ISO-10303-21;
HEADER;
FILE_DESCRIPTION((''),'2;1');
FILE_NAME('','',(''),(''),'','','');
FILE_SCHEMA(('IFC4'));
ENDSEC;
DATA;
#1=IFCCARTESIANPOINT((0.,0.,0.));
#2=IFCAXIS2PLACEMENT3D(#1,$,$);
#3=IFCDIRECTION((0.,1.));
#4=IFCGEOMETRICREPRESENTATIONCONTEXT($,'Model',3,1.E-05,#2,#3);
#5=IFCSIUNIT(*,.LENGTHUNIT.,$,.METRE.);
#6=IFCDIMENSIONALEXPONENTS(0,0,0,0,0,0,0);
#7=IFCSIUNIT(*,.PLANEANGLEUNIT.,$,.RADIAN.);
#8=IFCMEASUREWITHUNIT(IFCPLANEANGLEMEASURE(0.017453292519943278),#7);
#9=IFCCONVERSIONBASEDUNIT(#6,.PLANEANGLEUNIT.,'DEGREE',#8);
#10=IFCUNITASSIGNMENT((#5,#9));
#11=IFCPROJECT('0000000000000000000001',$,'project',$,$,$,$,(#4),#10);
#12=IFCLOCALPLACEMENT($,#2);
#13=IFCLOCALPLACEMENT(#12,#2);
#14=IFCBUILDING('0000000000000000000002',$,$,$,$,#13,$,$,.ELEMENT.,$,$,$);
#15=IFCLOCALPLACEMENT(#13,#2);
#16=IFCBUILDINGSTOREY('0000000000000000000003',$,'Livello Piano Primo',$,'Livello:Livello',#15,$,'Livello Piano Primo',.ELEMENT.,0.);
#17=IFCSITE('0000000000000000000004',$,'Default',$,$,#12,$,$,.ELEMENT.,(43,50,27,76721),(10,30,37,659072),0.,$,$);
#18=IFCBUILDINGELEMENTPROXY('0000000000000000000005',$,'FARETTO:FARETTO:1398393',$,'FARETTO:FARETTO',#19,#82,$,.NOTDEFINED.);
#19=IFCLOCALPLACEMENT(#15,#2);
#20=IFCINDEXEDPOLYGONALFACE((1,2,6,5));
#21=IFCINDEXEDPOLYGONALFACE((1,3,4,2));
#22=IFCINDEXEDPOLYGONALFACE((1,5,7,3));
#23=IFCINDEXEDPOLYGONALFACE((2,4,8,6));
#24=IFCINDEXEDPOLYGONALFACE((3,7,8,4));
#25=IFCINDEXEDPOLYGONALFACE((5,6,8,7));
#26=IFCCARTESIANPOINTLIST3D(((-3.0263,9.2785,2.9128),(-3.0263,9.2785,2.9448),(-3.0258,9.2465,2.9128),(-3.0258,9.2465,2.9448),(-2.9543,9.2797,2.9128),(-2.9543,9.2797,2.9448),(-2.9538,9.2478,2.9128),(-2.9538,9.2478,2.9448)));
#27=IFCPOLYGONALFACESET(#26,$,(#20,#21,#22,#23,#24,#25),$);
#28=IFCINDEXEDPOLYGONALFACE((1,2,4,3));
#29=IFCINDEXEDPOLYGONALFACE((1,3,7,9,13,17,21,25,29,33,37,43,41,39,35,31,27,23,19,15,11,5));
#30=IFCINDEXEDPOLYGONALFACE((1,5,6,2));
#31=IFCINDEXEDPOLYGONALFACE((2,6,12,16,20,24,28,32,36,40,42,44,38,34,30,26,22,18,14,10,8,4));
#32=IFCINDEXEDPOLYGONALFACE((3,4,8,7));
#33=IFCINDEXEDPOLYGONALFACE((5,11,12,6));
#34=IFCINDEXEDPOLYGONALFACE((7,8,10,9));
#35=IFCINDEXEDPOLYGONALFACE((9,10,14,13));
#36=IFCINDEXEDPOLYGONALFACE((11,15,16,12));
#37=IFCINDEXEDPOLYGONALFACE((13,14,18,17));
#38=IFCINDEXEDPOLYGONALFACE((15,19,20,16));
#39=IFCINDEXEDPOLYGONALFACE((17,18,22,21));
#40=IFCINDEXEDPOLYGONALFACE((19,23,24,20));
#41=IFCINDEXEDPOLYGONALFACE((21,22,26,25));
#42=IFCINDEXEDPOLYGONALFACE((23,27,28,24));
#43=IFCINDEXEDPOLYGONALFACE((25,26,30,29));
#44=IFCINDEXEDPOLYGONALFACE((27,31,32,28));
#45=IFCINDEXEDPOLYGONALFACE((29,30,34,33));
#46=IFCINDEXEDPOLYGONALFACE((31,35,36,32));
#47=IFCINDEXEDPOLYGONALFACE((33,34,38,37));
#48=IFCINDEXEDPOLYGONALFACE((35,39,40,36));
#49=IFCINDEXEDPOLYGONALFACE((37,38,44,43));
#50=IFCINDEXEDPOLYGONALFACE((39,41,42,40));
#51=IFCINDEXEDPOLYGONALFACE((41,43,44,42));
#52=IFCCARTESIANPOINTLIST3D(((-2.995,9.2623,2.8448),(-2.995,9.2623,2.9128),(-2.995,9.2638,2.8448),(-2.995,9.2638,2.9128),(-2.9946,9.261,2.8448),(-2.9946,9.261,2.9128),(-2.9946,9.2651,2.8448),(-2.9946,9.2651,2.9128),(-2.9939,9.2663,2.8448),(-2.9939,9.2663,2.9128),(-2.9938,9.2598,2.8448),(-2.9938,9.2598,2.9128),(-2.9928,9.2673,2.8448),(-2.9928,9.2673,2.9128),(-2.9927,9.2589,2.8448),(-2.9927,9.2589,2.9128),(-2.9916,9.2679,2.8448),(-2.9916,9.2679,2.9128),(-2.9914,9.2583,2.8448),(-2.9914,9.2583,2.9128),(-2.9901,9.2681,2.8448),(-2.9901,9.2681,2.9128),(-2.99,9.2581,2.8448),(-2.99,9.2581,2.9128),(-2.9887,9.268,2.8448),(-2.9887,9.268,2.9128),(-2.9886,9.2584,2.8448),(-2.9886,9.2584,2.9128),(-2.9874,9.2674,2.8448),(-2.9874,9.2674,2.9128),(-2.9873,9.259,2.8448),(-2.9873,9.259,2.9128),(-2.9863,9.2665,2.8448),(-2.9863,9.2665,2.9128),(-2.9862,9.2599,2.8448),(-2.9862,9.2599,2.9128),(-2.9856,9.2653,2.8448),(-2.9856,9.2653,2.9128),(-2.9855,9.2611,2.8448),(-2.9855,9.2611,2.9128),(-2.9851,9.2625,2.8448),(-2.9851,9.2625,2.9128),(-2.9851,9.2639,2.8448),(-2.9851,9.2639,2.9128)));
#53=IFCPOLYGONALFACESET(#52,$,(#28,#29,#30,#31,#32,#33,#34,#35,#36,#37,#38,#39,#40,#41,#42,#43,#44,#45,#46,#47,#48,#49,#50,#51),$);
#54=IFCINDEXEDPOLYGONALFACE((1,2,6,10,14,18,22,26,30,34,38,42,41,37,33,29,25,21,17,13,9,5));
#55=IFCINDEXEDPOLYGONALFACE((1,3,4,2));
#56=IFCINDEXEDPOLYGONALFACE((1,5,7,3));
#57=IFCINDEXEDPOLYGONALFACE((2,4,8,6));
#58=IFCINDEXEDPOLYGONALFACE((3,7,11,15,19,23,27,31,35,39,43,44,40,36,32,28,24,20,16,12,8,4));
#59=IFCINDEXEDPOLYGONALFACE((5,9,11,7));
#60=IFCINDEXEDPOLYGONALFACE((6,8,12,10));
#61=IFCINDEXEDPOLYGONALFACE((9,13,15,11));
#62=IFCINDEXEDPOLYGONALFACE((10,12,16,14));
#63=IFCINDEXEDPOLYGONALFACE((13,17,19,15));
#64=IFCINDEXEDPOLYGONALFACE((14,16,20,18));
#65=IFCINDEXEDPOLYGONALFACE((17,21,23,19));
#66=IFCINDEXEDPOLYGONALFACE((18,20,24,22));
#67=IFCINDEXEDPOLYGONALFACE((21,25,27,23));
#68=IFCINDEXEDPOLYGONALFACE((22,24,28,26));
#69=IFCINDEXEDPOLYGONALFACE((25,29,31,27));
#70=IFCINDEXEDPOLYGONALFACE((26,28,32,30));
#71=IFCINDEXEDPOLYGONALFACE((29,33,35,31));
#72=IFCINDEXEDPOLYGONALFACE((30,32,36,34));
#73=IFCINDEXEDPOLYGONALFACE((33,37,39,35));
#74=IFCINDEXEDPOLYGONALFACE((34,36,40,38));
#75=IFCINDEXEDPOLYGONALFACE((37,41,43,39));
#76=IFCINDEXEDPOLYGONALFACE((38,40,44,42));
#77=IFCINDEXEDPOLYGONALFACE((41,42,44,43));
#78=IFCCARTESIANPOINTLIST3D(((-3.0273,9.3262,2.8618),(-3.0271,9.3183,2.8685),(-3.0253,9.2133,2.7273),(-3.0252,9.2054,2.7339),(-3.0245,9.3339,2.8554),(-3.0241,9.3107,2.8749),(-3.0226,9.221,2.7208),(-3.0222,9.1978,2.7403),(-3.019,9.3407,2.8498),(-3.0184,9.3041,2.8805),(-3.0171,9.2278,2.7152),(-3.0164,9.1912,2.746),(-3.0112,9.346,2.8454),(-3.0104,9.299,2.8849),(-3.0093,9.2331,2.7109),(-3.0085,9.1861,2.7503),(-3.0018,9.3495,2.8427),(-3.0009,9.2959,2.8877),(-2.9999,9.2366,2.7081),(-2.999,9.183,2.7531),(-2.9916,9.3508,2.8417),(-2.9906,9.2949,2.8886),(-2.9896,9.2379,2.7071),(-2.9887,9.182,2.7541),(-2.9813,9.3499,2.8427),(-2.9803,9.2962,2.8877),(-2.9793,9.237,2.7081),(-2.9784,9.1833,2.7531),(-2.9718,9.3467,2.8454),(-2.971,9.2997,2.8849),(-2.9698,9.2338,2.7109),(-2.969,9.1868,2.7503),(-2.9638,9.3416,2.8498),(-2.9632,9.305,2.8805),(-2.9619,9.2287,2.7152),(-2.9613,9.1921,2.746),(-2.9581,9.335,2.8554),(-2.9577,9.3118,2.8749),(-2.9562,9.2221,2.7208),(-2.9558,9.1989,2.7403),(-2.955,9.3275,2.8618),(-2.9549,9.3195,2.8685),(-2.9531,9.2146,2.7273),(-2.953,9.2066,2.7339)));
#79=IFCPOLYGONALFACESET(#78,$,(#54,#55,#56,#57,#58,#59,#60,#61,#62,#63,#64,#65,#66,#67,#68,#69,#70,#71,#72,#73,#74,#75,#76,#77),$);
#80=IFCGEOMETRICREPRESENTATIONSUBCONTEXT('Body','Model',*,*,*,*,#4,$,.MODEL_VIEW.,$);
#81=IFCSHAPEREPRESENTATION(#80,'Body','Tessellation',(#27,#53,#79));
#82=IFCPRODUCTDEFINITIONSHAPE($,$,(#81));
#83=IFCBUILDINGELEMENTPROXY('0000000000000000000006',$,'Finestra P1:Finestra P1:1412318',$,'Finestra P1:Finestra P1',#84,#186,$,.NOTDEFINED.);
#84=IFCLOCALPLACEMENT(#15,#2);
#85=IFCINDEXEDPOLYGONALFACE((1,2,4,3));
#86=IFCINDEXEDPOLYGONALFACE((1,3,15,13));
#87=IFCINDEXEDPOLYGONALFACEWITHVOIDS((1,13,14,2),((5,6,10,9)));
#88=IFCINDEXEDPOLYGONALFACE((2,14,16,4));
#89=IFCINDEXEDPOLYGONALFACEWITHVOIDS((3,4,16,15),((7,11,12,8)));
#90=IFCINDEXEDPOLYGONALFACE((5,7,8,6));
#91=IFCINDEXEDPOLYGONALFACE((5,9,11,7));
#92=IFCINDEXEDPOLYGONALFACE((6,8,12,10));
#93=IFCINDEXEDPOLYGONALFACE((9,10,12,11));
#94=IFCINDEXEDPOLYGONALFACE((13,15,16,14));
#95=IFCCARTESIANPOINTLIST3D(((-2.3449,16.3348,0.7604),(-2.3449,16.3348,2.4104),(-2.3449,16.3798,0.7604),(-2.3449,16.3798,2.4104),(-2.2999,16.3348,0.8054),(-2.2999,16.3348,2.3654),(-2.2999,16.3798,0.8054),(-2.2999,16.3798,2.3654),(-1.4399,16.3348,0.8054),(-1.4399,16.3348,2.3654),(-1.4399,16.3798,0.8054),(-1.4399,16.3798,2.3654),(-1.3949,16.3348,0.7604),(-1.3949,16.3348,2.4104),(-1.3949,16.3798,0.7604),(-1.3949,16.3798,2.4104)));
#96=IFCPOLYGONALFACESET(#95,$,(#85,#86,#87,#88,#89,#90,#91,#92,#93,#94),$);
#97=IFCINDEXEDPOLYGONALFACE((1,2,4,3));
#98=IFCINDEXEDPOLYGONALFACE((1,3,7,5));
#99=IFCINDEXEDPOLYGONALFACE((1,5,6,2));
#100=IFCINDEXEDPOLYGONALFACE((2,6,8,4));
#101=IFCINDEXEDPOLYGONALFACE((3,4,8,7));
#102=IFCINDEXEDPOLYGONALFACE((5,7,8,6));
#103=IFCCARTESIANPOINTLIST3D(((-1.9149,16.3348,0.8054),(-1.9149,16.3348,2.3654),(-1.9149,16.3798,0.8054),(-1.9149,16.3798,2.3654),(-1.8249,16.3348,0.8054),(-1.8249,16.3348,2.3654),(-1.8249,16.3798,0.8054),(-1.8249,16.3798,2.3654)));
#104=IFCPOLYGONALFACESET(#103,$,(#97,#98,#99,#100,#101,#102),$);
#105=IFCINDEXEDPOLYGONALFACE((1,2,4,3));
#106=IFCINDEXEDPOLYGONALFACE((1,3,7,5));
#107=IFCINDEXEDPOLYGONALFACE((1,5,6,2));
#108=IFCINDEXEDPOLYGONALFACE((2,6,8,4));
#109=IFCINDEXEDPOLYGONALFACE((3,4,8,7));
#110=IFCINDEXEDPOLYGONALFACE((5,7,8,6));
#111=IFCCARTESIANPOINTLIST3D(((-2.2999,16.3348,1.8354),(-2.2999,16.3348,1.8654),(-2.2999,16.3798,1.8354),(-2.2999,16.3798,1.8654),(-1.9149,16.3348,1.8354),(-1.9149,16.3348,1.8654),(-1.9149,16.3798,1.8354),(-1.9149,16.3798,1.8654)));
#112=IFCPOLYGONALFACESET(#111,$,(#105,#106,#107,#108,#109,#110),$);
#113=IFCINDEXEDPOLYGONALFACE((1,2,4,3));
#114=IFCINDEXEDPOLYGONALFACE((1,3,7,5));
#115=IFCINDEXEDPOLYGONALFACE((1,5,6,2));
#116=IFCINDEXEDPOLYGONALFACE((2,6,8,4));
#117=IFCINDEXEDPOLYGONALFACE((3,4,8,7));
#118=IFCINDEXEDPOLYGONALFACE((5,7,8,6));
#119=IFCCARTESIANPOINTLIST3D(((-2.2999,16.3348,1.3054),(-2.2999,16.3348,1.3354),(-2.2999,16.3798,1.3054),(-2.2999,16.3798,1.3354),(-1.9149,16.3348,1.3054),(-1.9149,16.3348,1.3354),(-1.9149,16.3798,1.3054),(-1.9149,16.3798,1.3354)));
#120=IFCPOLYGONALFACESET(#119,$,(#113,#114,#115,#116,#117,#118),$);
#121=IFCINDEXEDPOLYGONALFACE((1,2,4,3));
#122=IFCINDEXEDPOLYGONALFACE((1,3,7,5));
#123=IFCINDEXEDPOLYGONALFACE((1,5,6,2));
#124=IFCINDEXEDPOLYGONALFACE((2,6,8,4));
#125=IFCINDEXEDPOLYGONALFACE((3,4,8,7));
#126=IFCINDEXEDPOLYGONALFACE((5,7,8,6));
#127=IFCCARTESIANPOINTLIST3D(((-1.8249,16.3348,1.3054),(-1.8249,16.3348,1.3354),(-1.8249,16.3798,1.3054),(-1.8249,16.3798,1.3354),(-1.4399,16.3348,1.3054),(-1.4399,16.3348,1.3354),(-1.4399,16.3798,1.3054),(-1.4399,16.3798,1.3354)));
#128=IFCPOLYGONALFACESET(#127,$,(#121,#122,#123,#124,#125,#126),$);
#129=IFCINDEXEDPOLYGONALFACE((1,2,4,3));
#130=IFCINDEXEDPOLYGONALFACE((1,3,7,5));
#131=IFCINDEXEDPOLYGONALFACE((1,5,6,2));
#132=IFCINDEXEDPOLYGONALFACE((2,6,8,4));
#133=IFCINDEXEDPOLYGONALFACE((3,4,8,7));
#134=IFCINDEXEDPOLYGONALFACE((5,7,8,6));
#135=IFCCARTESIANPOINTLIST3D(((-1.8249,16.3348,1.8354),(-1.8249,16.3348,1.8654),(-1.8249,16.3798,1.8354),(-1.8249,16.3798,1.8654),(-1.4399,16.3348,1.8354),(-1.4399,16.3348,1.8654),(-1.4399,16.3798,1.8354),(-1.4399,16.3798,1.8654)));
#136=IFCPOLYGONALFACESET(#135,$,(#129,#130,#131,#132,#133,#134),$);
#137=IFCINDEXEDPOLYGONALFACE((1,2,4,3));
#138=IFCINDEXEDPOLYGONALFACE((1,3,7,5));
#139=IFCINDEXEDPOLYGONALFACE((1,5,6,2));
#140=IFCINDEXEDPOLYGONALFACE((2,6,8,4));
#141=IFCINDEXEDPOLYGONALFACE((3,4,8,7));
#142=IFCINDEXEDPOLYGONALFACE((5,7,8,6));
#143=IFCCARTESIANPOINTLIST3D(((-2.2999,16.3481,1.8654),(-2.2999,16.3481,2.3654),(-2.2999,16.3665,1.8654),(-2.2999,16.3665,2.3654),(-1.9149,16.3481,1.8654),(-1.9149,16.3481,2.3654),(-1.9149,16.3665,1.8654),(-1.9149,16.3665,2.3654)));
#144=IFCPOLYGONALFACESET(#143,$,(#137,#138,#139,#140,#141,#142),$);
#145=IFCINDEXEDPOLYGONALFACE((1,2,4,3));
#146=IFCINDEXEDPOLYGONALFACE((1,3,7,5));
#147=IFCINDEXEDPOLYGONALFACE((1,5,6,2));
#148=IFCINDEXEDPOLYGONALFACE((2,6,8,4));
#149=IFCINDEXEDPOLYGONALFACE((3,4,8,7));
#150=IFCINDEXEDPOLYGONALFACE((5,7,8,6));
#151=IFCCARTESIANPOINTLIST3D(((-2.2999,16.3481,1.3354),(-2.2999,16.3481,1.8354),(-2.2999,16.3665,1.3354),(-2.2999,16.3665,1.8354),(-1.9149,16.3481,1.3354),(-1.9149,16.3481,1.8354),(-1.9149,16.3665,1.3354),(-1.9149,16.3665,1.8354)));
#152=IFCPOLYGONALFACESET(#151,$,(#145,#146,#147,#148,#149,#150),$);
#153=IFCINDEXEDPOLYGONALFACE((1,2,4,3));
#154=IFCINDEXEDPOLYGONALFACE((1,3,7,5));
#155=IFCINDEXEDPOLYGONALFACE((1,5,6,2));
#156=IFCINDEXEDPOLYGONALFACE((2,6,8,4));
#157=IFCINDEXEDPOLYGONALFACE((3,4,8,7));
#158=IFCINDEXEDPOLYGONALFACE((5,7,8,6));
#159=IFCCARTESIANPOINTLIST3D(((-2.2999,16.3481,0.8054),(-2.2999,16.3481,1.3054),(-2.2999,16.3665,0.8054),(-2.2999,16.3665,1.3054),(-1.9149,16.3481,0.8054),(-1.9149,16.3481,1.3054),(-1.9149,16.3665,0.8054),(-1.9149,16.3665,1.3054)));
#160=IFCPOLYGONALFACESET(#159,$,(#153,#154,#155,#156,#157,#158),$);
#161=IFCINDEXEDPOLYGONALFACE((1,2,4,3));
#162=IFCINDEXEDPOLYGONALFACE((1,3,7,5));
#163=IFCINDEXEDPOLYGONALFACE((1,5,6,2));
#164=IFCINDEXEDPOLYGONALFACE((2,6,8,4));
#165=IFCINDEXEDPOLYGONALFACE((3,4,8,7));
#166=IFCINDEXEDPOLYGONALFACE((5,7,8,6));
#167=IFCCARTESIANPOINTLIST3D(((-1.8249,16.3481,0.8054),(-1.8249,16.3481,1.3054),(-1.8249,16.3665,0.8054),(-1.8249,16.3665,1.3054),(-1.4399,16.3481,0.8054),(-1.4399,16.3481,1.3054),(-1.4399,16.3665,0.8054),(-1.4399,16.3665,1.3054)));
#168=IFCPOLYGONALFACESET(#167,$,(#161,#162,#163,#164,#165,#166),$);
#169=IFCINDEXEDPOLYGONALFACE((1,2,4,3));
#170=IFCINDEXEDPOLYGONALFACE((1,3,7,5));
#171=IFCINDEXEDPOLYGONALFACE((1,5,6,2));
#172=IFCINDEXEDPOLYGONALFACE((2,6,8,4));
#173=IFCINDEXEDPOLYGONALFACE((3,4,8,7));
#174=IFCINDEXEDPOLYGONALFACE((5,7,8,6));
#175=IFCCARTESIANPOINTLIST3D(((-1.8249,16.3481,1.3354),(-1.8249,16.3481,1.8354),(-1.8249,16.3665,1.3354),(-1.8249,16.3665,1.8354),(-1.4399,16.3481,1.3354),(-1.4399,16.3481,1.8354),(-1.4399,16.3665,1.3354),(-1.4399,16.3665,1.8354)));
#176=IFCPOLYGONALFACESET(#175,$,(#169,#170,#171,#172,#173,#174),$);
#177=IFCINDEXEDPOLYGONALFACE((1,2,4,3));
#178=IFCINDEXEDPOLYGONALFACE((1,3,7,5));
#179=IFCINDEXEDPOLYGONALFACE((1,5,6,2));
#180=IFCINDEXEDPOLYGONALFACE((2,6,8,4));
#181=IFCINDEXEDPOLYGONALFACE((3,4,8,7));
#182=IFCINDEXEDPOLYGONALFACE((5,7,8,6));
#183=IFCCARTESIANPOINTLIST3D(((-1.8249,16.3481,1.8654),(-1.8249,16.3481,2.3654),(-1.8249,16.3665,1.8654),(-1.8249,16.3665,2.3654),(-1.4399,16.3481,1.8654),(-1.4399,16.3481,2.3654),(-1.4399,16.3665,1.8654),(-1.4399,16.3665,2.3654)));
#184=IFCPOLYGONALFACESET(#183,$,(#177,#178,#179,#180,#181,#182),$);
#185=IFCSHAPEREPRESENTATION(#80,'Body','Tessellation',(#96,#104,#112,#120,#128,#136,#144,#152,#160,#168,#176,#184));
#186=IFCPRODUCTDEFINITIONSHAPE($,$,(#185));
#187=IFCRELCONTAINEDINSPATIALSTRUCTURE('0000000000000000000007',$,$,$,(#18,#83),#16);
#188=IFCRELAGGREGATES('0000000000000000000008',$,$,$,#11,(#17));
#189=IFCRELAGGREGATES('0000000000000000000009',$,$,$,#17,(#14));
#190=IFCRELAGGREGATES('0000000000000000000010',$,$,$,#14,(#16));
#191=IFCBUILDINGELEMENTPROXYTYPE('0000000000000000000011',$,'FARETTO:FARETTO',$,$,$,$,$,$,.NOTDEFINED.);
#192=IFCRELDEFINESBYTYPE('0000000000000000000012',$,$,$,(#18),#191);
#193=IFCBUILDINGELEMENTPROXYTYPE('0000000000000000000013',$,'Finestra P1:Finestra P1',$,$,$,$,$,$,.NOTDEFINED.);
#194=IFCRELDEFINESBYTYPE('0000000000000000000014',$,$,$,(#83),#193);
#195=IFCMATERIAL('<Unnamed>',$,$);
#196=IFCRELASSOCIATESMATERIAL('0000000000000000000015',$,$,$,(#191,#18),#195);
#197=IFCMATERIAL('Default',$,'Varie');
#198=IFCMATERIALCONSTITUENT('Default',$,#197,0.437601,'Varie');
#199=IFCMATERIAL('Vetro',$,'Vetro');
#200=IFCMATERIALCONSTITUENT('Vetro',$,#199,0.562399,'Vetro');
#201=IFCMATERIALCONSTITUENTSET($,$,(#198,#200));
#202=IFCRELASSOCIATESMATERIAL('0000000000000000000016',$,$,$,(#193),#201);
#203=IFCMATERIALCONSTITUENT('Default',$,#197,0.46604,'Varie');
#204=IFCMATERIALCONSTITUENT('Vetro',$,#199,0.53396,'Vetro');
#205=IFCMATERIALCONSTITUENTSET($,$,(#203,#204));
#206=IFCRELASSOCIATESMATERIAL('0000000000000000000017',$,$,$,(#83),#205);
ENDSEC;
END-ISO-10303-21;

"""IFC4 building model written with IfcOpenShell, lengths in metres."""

from ifc_helpers import new_model, entity, si_unit, converted_unit, direction, frame, origin, place, context, subcontext, project, spatial, arc, indexed_curve, outline, extrude, source, transform, mapped, material, constituent, constituent_set, type_object, type_shapes, element, save


model = new_model("IFC4")

# Units and contexts
model_context = context("Model", 3, precision=1e-05, world=origin(), true_north=direction((0.0, 1.0)))
body_context = subcontext(model_context, "Body", "Model", "MODEL_VIEW")
ifc_project = project(units=[si_unit("LENGTHUNIT", "METRE"), converted_unit("PLANEANGLEUNIT", "DEGREE", entity("IfcPlaneAngleMeasure", 0.017453292519943278), si_unit("PLANEANGLEUNIT", "RADIAN"), dimensions=[0, 0, 0, 0, 0, 0, 0])], contexts=[model_context])

# Site, building, storey
site_placement = place(None, origin())
site = spatial("IfcSite", under=ifc_project, at=site_placement, Name="Default", CompositionType="ELEMENT", RefLatitude=(43, 50, 27, 76721), RefLongitude=(10, 30, 37, 659072), RefElevation=0.0)
building_placement = place(site_placement, origin())
building = spatial("IfcBuilding", under=site, at=building_placement, CompositionType="ELEMENT")
storey_placement = place(building_placement, origin())
storey = spatial("IfcBuildingStorey", under=building, at=storey_placement, Name="Livello Piano Primo", ObjectType="Livello:Livello", LongName="Livello Piano Primo", CompositionType="ELEMENT", Elevation=0.0)

# Building element proxies
ifc_material_1 = material(Name="Default", Category="Varie")
ifc_material_2 = material(Name="Vetro", Category="Vetro")
ifc_material_3 = material(Name="<Unnamed>")
building_element_proxy_type_1 = type_object("IfcBuildingElementProxyType", Name="FARETTO:FARETTO", PredefinedType="NOTDEFINED", material=ifc_material_3)
shared_shape_1 = source(origin(), body_context, "Body", "SweptSolid", [
    extrude(outline(indexed_curve([(-0.036, -0.016), (0.036, -0.016), (0.036, 0.016), (-0.036, 0.016), (-0.036, -0.016)], self_intersect=False)), frame((0.032, 0.0, 0.0), z_axis=(0.0, 0.0, 1.0), x_axis=(0.0, 1.0, 0.0)), (0.0, 0.0, 1.0), 0.032),
    extrude(outline(indexed_curve([(-0.005, 0.0), (0.0, -0.005), (0.005, 0.0), (0.0, 0.005)], segments=[arc(1, 2, 3), arc(3, 4, 1)], self_intersect=False)), frame((0.032, 0.0, 0.032)), (0.0, 0.0, 1.0), 0.068),
    extrude(outline(indexed_curve([(-0.0365, 0.0), (0.0, -0.0365), (0.0365, 0.0), (0.0, 0.0365)], segments=[arc(1, 2, 3), arc(3, 4, 1)], self_intersect=False)), frame((-0.0277, 0.0, 0.0796), z_axis=(0.642788, 0.0, 0.766044), x_axis=(0.766044, 0.0, -0.642788)), (0.0, 0.0, 1.0), 0.1757),
])
type_shapes(building_element_proxy_type_1, [shared_shape_1])
for number, where, z_axis, x_axis, name in (
    (1, (-2.9906, 9.2951, 2.9448), (0.0, 0.0, -1.0), (0.017041, -0.999855, 0.0), "FARETTO:FARETTO:1398393"),
):
    element("IfcBuildingElementProxy", number, at=place(storey_placement, frame(where, z_axis=z_axis, x_axis=x_axis)), inside=storey, type_object=building_element_proxy_type_1, material=ifc_material_3, Name=name, ObjectType="FARETTO:FARETTO", PredefinedType="NOTDEFINED", context=body_context, shape_type="MappedRepresentation", body=[
        mapped(shared_shape_1, transform((0.0, 0.0, 0.0), scale=1.0)),
    ])
ifc_constituent_1 = constituent(ifc_material_1, Name="Default", Category="Varie", fraction=0.46604)
ifc_constituent_2 = constituent(ifc_material_2, Name="Vetro", Category="Vetro", fraction=0.53396)
ifc_constituent_set_1 = constituent_set(constituents=[ifc_constituent_1, ifc_constituent_2])
ifc_constituent_3 = constituent(ifc_material_1, Name="Default", Category="Varie", fraction=0.437601)
ifc_constituent_4 = constituent(ifc_material_2, Name="Vetro", Category="Vetro", fraction=0.562399)
ifc_constituent_set_2 = constituent_set(constituents=[ifc_constituent_3, ifc_constituent_4])
building_element_proxy_type_2 = type_object("IfcBuildingElementProxyType", Name="Finestra P1:Finestra P1", PredefinedType="NOTDEFINED", material=ifc_constituent_set_2)
shared_shape_2 = source(origin(), body_context, "Body", "SweptSolid", [
    extrude(outline(indexed_curve([(-0.825, -0.475), (0.825, -0.475), (0.825, 0.475), (-0.825, 0.475), (-0.825, -0.475)], self_intersect=False), holes=[indexed_curve([(0.78, -0.43), (-0.78, -0.43), (-0.78, 0.43), (0.78, 0.43), (0.78, -0.43)], self_intersect=False)]), frame((0.0, -0.0225, 0.825), z_axis=(0.0, 1.0, 0.0), x_axis=(0.0, 0.0, -1.0)), (0.0, 0.0, 1.0), 0.045),
    extrude(outline(indexed_curve([(-0.045, -0.0225), (0.045, -0.0225), (0.045, 0.0225), (-0.045, 0.0225), (-0.045, -0.0225)], self_intersect=False)), frame((0.0, 0.0, 0.045), z_axis=(0.0, 0.0, 1.0), x_axis=(-1.0, 0.0, 0.0)), (0.0, 0.0, 1.0), 1.56),
    extrude(outline(indexed_curve([(-0.1925, -0.0225), (0.1925, -0.0225), (0.1925, 0.0225), (-0.1925, 0.0225), (-0.1925, -0.0225)], self_intersect=False)), frame((0.2375, 0.0, 1.075)), (0.0, 0.0, 1.0), 0.03),
    extrude(outline(indexed_curve([(-0.1925, -0.0225), (0.1925, -0.0225), (0.1925, 0.0225), (-0.1925, 0.0225), (-0.1925, -0.0225)], self_intersect=False)), frame((0.2375, 0.0, 0.545)), (0.0, 0.0, 1.0), 0.03),
    extrude(outline(indexed_curve([(-0.1925, -0.0225), (0.1925, -0.0225), (0.1925, 0.0225), (-0.1925, 0.0225), (-0.1925, -0.0225)], self_intersect=False)), frame((-0.2375, 0.0, 0.545)), (0.0, 0.0, 1.0), 0.03),
    extrude(outline(indexed_curve([(-0.1925, -0.0225), (0.1925, -0.0225), (0.1925, 0.0225), (-0.1925, 0.0225), (-0.1925, -0.0225)], self_intersect=False)), frame((-0.2375, 0.0, 1.075)), (0.0, 0.0, 1.0), 0.03),
    extrude(outline(indexed_curve([(-0.1925, -0.0092), (0.1925, -0.0092), (0.1925, 0.0092), (-0.1925, 0.0092), (-0.1925, -0.0092)], self_intersect=False)), frame((0.2375, 0.0, 1.105), z_axis=(0.0, 0.0, 1.0), x_axis=(-1.0, 0.0, 0.0)), (0.0, 0.0, 1.0), 0.5),
    extrude(outline(indexed_curve([(-0.1925, -0.0092), (0.1925, -0.0092), (0.1925, 0.0092), (-0.1925, 0.0092), (-0.1925, -0.0092)], self_intersect=False)), frame((0.2375, 0.0, 0.575), z_axis=(0.0, 0.0, 1.0), x_axis=(-1.0, 0.0, 0.0)), (0.0, 0.0, 1.0), 0.5),
    extrude(outline(indexed_curve([(-0.1925, -0.0092), (0.1925, -0.0092), (0.1925, 0.0092), (-0.1925, 0.0092), (-0.1925, -0.0092)], self_intersect=False)), frame((0.2375, 0.0, 0.045), z_axis=(0.0, 0.0, 1.0), x_axis=(-1.0, 0.0, 0.0)), (0.0, 0.0, 1.0), 0.5),
    extrude(outline(indexed_curve([(-0.1925, -0.0092), (0.1925, -0.0092), (0.1925, 0.0092), (-0.1925, 0.0092), (-0.1925, -0.0092)], self_intersect=False)), frame((-0.2375, 0.0, 0.045), z_axis=(0.0, 0.0, 1.0), x_axis=(-1.0, 0.0, 0.0)), (0.0, 0.0, 1.0), 0.5),
    extrude(outline(indexed_curve([(-0.1925, -0.0092), (0.1925, -0.0092), (0.1925, 0.0092), (-0.1925, 0.0092), (-0.1925, -0.0092)], self_intersect=False)), frame((-0.2375, 0.0, 0.575), z_axis=(0.0, 0.0, 1.0), x_axis=(-1.0, 0.0, 0.0)), (0.0, 0.0, 1.0), 0.5),
    extrude(outline(indexed_curve([(-0.1925, -0.0092), (0.1925, -0.0092), (0.1925, 0.0092), (-0.1925, 0.0092), (-0.1925, -0.0092)], self_intersect=False)), frame((-0.2375, 0.0, 1.105), z_axis=(0.0, 0.0, 1.0), x_axis=(-1.0, 0.0, 0.0)), (0.0, 0.0, 1.0), 0.5),
])
type_shapes(building_element_proxy_type_2, [shared_shape_2])
proxy_1_placement = place(storey_placement, frame((-1.8699, 16.3573, 0.7604), z_axis=(0.0, 0.0, 1.0), x_axis=(-1.0, 0.0, 0.0)))
element("IfcBuildingElementProxy", 2, at=proxy_1_placement, inside=storey, type_object=building_element_proxy_type_2, material=ifc_constituent_set_1, Name="Finestra P1:Finestra P1:1412318", ObjectType="Finestra P1:Finestra P1", PredefinedType="NOTDEFINED", context=body_context, shape_type="MappedRepresentation", body=[
    mapped(shared_shape_2, transform((0.0, 0.0, 0.0), scale=1.0)),
])

save(model, "model.ifc")
